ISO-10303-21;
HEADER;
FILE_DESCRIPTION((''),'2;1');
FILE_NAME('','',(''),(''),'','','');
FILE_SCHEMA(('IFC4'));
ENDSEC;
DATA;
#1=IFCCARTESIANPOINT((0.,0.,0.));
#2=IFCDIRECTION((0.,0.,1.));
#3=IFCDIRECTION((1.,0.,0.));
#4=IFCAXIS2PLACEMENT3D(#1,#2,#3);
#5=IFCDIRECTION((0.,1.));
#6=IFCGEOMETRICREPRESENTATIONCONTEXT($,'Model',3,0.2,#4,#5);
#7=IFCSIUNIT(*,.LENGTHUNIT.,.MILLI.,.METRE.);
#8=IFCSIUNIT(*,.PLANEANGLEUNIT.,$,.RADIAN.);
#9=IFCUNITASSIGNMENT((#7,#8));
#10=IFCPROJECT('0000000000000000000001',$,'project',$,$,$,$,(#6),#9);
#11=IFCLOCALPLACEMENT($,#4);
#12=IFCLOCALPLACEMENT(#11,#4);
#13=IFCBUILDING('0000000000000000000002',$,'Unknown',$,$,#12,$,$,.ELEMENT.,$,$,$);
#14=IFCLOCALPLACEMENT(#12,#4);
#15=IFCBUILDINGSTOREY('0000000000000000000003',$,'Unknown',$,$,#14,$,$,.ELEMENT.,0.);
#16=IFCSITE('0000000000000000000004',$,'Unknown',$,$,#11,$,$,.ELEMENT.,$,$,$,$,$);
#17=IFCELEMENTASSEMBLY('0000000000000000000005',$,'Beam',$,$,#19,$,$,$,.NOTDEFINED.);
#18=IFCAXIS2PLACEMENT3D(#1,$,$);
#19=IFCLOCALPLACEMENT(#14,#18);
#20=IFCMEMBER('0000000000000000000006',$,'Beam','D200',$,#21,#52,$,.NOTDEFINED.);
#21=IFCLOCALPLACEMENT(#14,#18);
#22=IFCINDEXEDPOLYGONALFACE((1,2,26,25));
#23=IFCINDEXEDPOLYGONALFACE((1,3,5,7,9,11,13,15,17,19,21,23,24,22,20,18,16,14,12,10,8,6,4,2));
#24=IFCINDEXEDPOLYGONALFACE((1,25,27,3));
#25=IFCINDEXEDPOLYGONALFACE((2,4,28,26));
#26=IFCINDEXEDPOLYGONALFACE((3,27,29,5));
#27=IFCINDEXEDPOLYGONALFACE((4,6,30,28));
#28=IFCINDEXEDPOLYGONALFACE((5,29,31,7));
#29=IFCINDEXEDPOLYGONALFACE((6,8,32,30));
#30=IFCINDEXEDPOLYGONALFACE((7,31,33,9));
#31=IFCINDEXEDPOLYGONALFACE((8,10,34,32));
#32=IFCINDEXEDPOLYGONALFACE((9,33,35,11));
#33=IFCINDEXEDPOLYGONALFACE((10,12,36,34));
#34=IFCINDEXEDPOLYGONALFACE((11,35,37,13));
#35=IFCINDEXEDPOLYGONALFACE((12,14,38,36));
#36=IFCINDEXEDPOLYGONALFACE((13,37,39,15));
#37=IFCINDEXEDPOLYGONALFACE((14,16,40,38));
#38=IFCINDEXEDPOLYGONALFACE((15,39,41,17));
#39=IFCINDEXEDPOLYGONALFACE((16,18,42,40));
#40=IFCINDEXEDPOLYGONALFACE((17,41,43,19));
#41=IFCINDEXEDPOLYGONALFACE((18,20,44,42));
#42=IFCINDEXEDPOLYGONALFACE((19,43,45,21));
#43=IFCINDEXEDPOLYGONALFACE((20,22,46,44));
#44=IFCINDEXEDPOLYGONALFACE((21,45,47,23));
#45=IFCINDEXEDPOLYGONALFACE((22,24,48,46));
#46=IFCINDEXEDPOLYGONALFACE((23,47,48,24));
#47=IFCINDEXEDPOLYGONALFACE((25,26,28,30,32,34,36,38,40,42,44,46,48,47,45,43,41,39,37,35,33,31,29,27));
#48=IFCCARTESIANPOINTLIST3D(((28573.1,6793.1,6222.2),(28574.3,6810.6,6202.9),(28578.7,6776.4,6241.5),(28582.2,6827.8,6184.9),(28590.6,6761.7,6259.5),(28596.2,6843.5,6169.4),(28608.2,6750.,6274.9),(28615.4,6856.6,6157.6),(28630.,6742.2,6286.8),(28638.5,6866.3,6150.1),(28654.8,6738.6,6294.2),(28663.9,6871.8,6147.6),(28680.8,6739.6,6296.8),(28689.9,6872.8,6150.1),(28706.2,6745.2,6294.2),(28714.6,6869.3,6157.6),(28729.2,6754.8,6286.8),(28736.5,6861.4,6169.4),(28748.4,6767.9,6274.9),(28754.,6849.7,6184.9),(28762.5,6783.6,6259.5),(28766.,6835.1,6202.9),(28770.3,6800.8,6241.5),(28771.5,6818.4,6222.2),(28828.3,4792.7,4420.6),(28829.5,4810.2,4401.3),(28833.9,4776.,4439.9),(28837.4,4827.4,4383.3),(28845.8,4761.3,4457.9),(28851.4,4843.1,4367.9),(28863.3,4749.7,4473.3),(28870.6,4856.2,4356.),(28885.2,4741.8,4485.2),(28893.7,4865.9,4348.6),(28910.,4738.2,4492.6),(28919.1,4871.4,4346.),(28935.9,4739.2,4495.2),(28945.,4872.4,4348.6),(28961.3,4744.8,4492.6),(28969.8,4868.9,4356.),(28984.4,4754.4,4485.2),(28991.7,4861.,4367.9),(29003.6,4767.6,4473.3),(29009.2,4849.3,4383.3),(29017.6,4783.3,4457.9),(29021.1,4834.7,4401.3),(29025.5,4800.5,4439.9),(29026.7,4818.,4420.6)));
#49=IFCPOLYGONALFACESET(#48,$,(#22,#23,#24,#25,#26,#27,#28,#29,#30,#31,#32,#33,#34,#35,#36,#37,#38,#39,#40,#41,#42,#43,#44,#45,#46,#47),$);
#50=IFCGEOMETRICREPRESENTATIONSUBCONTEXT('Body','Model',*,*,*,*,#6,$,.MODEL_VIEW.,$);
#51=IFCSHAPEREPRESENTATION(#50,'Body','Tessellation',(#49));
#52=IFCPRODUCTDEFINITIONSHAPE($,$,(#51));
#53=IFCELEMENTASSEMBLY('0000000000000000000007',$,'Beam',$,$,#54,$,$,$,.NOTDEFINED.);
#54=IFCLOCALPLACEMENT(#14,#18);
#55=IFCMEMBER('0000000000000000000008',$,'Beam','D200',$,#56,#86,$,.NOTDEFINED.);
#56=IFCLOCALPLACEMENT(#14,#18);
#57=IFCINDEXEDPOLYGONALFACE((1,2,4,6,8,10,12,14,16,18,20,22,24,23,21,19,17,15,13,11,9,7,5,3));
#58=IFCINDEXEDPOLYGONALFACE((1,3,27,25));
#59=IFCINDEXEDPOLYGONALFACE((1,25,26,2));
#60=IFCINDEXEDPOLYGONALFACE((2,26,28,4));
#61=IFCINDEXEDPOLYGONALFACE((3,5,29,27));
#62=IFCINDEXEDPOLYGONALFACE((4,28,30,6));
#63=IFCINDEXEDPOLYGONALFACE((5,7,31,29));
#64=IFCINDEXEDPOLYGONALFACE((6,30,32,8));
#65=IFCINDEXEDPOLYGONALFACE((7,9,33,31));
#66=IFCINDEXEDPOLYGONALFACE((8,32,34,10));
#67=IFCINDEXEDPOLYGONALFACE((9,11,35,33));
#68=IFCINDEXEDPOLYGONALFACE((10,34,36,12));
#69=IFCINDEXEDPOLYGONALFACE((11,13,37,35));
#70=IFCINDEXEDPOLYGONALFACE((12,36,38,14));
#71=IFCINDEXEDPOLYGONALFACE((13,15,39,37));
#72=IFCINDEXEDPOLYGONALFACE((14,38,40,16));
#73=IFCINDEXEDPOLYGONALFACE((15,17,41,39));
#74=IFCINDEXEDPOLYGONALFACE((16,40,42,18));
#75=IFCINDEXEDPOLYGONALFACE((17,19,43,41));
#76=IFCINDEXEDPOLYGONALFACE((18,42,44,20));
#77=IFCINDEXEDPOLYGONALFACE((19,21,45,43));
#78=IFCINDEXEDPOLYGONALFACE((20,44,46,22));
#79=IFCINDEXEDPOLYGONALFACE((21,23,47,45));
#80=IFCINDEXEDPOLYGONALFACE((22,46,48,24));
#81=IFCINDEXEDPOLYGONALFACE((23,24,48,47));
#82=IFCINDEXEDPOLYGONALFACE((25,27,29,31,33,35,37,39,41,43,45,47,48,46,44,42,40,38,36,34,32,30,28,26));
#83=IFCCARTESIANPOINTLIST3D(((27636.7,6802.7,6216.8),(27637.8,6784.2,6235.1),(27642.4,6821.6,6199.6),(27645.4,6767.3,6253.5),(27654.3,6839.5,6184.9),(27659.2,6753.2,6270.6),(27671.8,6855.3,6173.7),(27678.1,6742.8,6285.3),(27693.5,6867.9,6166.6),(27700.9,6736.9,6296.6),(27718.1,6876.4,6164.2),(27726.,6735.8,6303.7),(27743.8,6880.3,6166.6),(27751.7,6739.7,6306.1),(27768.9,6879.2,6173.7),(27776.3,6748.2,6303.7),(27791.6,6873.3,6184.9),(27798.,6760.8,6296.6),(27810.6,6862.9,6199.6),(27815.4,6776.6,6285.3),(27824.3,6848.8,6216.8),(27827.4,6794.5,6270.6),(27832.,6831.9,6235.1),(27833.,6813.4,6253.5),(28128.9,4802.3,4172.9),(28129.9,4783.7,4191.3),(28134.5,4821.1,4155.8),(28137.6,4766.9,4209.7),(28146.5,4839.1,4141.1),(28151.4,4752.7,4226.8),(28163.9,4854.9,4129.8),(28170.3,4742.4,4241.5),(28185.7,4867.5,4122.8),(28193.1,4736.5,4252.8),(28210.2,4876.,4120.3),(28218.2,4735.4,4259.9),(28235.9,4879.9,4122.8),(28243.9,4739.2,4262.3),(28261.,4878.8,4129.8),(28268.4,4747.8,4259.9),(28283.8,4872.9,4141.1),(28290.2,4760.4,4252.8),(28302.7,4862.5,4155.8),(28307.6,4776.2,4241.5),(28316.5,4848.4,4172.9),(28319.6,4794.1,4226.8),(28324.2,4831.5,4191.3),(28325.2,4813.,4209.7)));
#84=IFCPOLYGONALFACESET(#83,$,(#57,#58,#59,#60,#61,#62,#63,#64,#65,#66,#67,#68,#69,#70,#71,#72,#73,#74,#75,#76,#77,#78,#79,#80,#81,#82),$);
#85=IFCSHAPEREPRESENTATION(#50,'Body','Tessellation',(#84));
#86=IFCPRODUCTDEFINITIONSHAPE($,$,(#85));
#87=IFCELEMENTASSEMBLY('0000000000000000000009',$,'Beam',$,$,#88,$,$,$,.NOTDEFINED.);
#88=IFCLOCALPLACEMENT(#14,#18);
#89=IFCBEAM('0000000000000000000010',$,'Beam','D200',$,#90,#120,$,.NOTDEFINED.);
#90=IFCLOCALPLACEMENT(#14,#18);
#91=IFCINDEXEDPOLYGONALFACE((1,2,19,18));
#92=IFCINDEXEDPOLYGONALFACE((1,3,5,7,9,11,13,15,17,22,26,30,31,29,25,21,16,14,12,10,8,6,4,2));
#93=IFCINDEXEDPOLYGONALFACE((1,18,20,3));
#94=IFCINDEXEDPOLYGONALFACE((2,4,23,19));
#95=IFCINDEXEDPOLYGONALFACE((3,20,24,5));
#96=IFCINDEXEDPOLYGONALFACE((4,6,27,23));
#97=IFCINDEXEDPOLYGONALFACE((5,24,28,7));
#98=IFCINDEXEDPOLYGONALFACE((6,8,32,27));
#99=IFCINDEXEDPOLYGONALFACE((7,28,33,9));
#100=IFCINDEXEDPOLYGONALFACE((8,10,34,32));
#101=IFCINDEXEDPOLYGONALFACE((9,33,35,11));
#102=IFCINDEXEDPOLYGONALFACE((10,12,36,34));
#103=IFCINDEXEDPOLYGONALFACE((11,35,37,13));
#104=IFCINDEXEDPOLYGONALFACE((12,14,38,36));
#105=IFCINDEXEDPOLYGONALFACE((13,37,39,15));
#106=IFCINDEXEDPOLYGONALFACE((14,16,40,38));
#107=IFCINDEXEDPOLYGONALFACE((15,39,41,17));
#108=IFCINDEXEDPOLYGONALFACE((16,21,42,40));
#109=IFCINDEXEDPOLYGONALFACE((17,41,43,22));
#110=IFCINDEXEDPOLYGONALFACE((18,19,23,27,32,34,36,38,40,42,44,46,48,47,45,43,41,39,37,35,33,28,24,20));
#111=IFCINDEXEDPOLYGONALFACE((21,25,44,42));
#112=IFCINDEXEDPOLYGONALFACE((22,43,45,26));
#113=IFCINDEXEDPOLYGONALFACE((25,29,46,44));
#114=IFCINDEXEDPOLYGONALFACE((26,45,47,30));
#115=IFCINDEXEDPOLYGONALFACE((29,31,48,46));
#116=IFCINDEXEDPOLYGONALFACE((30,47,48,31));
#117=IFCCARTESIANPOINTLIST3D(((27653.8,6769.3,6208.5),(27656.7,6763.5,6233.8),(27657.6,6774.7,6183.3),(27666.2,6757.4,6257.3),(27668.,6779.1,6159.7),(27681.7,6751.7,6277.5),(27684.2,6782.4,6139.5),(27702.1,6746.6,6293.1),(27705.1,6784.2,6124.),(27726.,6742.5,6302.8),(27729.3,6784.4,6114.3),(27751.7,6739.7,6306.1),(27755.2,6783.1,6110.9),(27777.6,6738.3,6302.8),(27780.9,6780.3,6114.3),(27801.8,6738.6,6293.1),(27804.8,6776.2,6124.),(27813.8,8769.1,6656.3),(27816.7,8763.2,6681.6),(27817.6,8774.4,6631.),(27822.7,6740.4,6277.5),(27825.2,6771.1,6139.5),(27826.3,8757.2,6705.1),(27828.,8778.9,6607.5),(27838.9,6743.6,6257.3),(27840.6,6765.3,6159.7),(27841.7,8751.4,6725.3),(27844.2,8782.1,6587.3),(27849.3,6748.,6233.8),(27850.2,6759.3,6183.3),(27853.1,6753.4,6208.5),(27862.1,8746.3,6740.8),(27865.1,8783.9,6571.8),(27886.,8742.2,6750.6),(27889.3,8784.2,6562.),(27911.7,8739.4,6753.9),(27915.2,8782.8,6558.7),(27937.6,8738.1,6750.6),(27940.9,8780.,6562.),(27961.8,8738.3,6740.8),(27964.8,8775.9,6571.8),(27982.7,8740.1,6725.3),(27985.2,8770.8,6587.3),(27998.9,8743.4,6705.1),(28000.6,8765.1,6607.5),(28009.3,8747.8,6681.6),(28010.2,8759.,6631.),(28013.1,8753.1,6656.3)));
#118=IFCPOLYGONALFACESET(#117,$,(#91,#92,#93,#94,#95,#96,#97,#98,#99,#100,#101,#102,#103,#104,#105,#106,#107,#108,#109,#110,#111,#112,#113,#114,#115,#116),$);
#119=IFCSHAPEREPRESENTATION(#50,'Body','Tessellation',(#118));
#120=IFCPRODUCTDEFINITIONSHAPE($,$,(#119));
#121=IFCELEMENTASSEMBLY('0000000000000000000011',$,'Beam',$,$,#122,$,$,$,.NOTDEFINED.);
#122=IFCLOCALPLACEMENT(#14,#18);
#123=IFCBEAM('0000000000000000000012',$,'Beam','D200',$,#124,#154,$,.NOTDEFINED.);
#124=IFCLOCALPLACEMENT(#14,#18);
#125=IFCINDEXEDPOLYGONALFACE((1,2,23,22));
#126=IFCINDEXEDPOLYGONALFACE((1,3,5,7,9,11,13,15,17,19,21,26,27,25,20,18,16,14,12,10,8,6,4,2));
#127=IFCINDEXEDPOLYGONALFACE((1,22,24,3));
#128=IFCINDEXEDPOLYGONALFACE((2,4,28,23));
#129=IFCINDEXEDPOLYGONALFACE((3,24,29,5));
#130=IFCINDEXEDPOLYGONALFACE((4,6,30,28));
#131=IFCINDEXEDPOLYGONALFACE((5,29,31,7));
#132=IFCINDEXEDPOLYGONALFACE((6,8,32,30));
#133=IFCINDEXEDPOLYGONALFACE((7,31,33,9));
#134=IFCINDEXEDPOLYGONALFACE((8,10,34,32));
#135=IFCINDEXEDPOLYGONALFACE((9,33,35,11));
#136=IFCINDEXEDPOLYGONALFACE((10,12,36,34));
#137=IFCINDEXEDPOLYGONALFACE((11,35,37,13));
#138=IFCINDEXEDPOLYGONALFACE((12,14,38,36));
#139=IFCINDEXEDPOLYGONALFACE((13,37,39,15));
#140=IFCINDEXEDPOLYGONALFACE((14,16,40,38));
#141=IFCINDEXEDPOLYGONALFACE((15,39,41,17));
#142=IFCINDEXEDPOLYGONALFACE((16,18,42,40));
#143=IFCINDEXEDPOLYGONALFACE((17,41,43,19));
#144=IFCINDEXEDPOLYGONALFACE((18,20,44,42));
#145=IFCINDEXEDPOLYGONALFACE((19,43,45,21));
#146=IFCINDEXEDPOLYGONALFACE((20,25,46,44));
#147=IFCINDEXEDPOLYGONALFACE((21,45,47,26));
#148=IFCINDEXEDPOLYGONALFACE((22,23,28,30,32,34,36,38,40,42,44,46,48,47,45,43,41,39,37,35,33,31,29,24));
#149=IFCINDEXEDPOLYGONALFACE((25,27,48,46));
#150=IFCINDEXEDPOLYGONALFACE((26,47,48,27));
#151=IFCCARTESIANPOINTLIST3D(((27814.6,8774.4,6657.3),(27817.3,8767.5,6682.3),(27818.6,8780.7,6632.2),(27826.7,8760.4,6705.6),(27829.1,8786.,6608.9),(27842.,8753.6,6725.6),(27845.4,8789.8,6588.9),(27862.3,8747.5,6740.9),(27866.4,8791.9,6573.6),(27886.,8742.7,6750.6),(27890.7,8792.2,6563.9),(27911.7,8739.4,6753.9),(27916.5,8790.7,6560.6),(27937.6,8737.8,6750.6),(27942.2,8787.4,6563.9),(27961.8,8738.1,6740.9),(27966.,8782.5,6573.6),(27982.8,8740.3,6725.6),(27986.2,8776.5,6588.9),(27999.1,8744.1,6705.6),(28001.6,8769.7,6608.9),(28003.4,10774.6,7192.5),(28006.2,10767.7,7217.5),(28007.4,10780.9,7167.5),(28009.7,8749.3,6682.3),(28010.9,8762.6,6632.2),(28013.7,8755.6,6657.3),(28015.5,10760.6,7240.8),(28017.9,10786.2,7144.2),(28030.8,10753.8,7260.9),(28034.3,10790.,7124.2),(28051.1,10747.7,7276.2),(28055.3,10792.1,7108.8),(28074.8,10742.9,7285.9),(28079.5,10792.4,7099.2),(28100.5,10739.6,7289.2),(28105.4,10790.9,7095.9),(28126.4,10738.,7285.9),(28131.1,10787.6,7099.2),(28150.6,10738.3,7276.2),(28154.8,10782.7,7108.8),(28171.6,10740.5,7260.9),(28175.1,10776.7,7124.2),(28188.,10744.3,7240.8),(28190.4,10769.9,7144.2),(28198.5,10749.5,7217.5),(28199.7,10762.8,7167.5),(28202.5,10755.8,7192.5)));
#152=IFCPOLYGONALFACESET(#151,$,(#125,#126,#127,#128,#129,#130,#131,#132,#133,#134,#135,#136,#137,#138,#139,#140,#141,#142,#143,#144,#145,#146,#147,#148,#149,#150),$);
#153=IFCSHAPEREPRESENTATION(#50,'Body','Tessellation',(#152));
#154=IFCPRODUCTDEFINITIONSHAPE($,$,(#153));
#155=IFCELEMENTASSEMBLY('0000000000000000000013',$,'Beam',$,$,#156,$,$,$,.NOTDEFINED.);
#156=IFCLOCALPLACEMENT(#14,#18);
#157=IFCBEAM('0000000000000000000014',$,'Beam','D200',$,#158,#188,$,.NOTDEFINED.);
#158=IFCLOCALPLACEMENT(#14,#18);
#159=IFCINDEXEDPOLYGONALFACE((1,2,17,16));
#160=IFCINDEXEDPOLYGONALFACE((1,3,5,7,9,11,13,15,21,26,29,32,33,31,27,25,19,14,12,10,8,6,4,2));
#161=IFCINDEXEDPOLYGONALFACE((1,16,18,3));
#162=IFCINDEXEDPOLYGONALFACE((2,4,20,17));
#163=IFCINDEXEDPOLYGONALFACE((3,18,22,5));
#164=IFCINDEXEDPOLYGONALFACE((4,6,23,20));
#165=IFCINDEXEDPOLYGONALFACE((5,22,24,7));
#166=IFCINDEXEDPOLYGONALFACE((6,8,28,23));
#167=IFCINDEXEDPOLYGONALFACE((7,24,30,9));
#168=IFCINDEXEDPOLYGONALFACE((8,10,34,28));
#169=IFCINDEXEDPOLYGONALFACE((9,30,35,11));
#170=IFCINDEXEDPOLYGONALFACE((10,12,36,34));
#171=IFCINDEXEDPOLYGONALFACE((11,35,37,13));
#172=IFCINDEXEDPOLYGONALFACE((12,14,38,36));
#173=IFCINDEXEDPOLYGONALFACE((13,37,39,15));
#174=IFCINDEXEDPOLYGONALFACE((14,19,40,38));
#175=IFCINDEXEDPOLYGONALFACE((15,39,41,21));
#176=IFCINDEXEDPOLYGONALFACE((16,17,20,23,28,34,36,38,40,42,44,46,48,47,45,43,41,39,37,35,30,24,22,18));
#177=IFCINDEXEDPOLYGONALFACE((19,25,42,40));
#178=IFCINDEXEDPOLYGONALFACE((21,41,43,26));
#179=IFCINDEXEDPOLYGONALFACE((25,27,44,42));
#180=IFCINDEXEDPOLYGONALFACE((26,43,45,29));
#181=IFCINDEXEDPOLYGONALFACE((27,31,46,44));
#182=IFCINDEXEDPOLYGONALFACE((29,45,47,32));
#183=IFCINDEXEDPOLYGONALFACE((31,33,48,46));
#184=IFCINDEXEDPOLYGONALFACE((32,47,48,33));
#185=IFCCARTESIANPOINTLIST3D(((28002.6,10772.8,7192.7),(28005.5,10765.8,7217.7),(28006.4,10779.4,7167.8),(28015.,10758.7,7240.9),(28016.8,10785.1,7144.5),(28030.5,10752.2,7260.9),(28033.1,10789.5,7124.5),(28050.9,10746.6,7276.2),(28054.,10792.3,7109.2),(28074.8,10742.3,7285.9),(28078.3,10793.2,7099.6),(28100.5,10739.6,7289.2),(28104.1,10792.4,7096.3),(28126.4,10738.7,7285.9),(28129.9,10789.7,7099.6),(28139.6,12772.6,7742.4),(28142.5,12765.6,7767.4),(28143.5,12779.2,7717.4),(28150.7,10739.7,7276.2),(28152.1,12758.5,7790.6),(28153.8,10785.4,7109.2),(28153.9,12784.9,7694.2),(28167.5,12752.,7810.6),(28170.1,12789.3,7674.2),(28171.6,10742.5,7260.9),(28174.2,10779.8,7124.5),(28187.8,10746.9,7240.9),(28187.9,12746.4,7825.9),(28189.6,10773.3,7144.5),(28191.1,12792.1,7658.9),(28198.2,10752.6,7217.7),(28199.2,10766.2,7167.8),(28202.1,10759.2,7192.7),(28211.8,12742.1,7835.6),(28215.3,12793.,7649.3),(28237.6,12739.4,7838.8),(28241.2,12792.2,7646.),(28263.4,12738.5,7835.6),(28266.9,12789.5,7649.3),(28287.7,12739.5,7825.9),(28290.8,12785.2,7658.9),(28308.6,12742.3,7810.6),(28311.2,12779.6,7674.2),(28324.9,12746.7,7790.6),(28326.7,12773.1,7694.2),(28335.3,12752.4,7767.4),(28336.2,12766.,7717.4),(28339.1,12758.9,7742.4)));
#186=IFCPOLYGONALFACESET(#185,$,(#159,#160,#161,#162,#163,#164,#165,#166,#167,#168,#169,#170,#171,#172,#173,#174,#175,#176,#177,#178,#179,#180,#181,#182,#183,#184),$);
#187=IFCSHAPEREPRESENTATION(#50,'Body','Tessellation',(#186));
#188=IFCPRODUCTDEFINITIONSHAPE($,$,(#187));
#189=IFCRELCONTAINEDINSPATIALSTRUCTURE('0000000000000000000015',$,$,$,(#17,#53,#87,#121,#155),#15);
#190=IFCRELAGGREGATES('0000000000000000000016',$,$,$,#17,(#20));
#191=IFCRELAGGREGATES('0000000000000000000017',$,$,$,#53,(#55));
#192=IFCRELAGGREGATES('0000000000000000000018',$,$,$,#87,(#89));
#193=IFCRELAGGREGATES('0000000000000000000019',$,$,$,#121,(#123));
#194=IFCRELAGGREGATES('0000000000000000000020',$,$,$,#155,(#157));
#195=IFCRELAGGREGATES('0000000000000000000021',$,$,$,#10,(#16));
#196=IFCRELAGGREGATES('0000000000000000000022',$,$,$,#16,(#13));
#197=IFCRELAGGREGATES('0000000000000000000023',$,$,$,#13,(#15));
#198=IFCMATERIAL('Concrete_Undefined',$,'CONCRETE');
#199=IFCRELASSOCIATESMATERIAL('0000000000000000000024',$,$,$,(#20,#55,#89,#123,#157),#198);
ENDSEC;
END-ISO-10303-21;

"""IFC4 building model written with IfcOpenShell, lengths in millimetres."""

from ifc_helpers import new_model, si_unit, direction, frame, origin_with_axes, place, context, subcontext, project, spatial, line, indexed_curve, outline, extrude, material, element, aggregate, save


model = new_model("IFC4")

# Units and contexts
model_context = context("Model", 3, precision=0.2, world=origin_with_axes(), true_north=direction((0.0, 1.0)))
body_context = subcontext(model_context, "Body", "Model", "MODEL_VIEW")
ifc_project = project(units=[si_unit("LENGTHUNIT", "METRE", prefix="MILLI"), si_unit("PLANEANGLEUNIT", "RADIAN")], contexts=[model_context])

# Site, building, storey
site_placement = place(None, origin_with_axes())
site = spatial("IfcSite", under=ifc_project, at=site_placement, Name="Unknown", CompositionType="ELEMENT")
building_placement = place(site_placement, origin_with_axes())
building = spatial("IfcBuilding", under=site, at=building_placement, Name="Unknown", CompositionType="ELEMENT")
storey_placement = place(building_placement, origin_with_axes())
storey = spatial("IfcBuildingStorey", under=building, at=storey_placement, Name="Unknown", CompositionType="ELEMENT", Elevation=0.0)

# Element assemblies, members
assembly_1_placement = place(storey_placement, frame((28672.3, 6805.7, 6222.2), z_axis=(-0.991963, -0.126531, 0.0), x_axis=(0.09436, -0.739752, -0.66623)))
assembly_1 = element("IfcElementAssembly", 1, at=assembly_1_placement, inside=storey, Name="Beam", PredefinedType="NOTDEFINED")
ifc_material = material(Name="Concrete_Undefined", Category="CONCRETE")
member_1_placement = place(assembly_1_placement, origin_with_axes())
member_1 = element("IfcMember", 2, at=member_1_placement, material=ifc_material, Name="Beam", Description="D200", PredefinedType="NOTDEFINED", context=body_context, shape_type="SolidModel", body=[
    extrude(outline(indexed_curve([(100.0, 0.0), (96.6, 25.9), (86.6, 50.0), (70.7, 70.7), (50.0, 86.6), (25.9, 96.6), (0.0, 100.0), (-25.9, 96.6), (-50.0, 86.6), (-70.7, 70.7), (-86.6, 50.0), (-96.6, 25.9), (-100.0, 0.0), (-96.6, -25.9), (-86.6, -50.0), (-70.7, -70.7), (-50.0, -86.6), (-25.9, -96.6), (0.0, -100.0), (25.9, -96.6), (50.0, -86.6), (70.7, -70.7), (86.6, -50.0), (96.6, -25.9)], segments=[line(1, 2, 3, 4, 5, 6, 7, 8, 9, 10, 11, 12, 13, 14, 15, 16, 17, 18, 19, 20, 21, 22, 23, 24, 1)])), frame((0.0, 0.0, 0.0), z_axis=(-1.0, 0.0, 0.0), x_axis=(0.0, 0.0, 1.0)), (0.0, 0.0, -1.0), 2704.1),
])
aggregate(assembly_1, [member_1])
assembly_2_placement = place(storey_placement, frame((27734.9, 6808.0, 6235.1), z_axis=(-0.971042, -0.238909, 0.0), x_axis=(0.169602, -0.689344, -0.704301)))
assembly_2 = element("IfcElementAssembly", 3, at=assembly_2_placement, inside=storey, Name="Beam", PredefinedType="NOTDEFINED")
member_2_placement = place(assembly_2_placement, origin_with_axes())
member_2 = element("IfcMember", 4, at=member_2_placement, material=ifc_material, Name="Beam", Description="D200", PredefinedType="NOTDEFINED", context=body_context, shape_type="SolidModel", body=[
    extrude(outline(indexed_curve([(100.0, 0.0), (96.6, 25.9), (86.6, 50.0), (70.7, 70.7), (50.0, 86.6), (25.9, 96.6), (0.0, 100.0), (-25.9, 96.6), (-50.0, 86.6), (-70.7, 70.7), (-86.6, 50.0), (-96.6, 25.9), (-100.0, 0.0), (-96.6, -25.9), (-86.6, -50.0), (-70.7, -70.7), (-50.0, -86.6), (-25.9, -96.6), (0.0, -100.0), (25.9, -96.6), (50.0, -86.6), (70.7, -70.7), (86.6, -50.0), (96.6, -25.9)], segments=[line(1, 2, 3, 4, 5, 6, 7, 8, 9, 10, 11, 12, 13, 14, 15, 16, 17, 18, 19, 20, 21, 22, 23, 24, 1)])), frame((0.0, 0.0, 0.0), z_axis=(-1.0, 0.0, 0.0), x_axis=(0.0, 0.0, 1.0)), (0.0, 0.0, -1.0), 2901.9),
])
aggregate(assembly_2, [member_2])

# Element assemblies, beams
assembly_3_placement = place(storey_placement, frame((27913.4, 8761.1, 6656.3), z_axis=(-0.996814, 0.079756, 0.0), x_axis=(-0.077841, -0.972877, -0.217834)))
assembly_3 = element("IfcElementAssembly", 5, at=assembly_3_placement, inside=storey, Name="Beam", PredefinedType="NOTDEFINED")
beam_1_placement = place(assembly_3_placement, origin_with_axes())
beam_1 = element("IfcBeam", 6, at=beam_1_placement, material=ifc_material, Name="Beam", Description="D200", PredefinedType="NOTDEFINED", context=body_context, shape_type="SolidModel", body=[
    extrude(outline(indexed_curve([(100.0, 0.0), (96.6, 25.9), (86.6, 50.0), (70.7, 70.7), (50.0, 86.6), (25.9, 96.6), (0.0, 100.0), (-25.9, 96.6), (-50.0, 86.6), (-70.7, 70.7), (-86.6, 50.0), (-96.6, 25.9), (-100.0, 0.0), (-96.6, -25.9), (-86.6, -50.0), (-70.7, -70.7), (-50.0, -86.6), (-25.9, -96.6), (0.0, -100.0), (25.9, -96.6), (50.0, -86.6), (70.7, -70.7), (86.6, -50.0), (96.6, -25.9)], segments=[line(1, 2, 3, 4, 5, 6, 7, 8, 9, 10, 11, 12, 13, 14, 15, 16, 17, 18, 19, 20, 21, 22, 23, 24, 1)])), frame((0.0, 0.0, 0.0), z_axis=(-1.0, 0.0, 0.0), x_axis=(0.0, 0.0, 1.0)), (0.0, 0.0, -1.0), 2055.5),
])
aggregate(assembly_3, [beam_1])
assembly_4_placement = place(storey_placement, frame((28103.0, 10765.2, 7192.5), z_axis=(-0.995574, 0.093984, 0.0), x_axis=(-0.090816, -0.962016, -0.257443)))
assembly_4 = element("IfcElementAssembly", 7, at=assembly_4_placement, inside=storey, Name="Beam", PredefinedType="NOTDEFINED")
beam_2_placement = place(assembly_4_placement, origin_with_axes())
beam_2 = element("IfcBeam", 8, at=beam_2_placement, material=ifc_material, Name="Beam", Description="D200", PredefinedType="NOTDEFINED", context=body_context, shape_type="SolidModel", body=[
    extrude(outline(indexed_curve([(100.0, 0.0), (96.6, 25.9), (86.6, 50.0), (70.7, 70.7), (50.0, 86.6), (25.9, 96.6), (0.0, 100.0), (-25.9, 96.6), (-50.0, 86.6), (-70.7, 70.7), (-86.6, 50.0), (-96.6, 25.9), (-100.0, 0.0), (-96.6, -25.9), (-86.6, -50.0), (-70.7, -70.7), (-50.0, -86.6), (-25.9, -96.6), (0.0, -100.0), (25.9, -96.6), (50.0, -86.6), (70.7, -70.7), (86.6, -50.0), (96.6, -25.9)], segments=[line(1, 2, 3, 4, 5, 6, 7, 8, 9, 10, 11, 12, 13, 14, 15, 16, 17, 18, 19, 20, 21, 22, 23, 24, 1)])), frame((0.0, 0.0, 0.0), z_axis=(-1.0, 0.0, 0.0), x_axis=(0.0, 0.0, 1.0)), (0.0, 0.0, -1.0), 2079.2),
])
aggregate(assembly_4, [beam_2])
assembly_5_placement = place(storey_placement, frame((28239.4, 12765.8, 7742.4), z_axis=(-0.997661, 0.068361, 0.0), x_axis=(-0.065927, -0.962139, -0.264465)))
assembly_5 = element("IfcElementAssembly", 9, at=assembly_5_placement, inside=storey, Name="Beam", PredefinedType="NOTDEFINED")
beam_3_placement = place(assembly_5_placement, origin_with_axes())
beam_3 = element("IfcBeam", 10, at=beam_3_placement, material=ifc_material, Name="Beam", Description="D200", PredefinedType="NOTDEFINED", context=body_context, shape_type="SolidModel", body=[
    extrude(outline(indexed_curve([(100.0, 0.0), (96.6, 25.9), (86.6, 50.0), (70.7, 70.7), (50.0, 86.6), (25.9, 96.6), (0.0, 100.0), (-25.9, 96.6), (-50.0, 86.6), (-70.7, 70.7), (-86.6, 50.0), (-96.6, 25.9), (-100.0, 0.0), (-96.6, -25.9), (-86.6, -50.0), (-70.7, -70.7), (-50.0, -86.6), (-25.9, -96.6), (0.0, -100.0), (25.9, -96.6), (50.0, -86.6), (70.7, -70.7), (86.6, -50.0), (96.6, -25.9)], segments=[line(1, 2, 3, 4, 5, 6, 7, 8, 9, 10, 11, 12, 13, 14, 15, 16, 17, 18, 19, 20, 21, 22, 23, 24, 1)])), frame((0.0, 0.0, 0.0), z_axis=(-1.0, 0.0, 0.0), x_axis=(0.0, 0.0, 1.0)), (0.0, 0.0, -1.0), 2078.5),
])
aggregate(assembly_5, [beam_3])

save(model, "model.ifc")
